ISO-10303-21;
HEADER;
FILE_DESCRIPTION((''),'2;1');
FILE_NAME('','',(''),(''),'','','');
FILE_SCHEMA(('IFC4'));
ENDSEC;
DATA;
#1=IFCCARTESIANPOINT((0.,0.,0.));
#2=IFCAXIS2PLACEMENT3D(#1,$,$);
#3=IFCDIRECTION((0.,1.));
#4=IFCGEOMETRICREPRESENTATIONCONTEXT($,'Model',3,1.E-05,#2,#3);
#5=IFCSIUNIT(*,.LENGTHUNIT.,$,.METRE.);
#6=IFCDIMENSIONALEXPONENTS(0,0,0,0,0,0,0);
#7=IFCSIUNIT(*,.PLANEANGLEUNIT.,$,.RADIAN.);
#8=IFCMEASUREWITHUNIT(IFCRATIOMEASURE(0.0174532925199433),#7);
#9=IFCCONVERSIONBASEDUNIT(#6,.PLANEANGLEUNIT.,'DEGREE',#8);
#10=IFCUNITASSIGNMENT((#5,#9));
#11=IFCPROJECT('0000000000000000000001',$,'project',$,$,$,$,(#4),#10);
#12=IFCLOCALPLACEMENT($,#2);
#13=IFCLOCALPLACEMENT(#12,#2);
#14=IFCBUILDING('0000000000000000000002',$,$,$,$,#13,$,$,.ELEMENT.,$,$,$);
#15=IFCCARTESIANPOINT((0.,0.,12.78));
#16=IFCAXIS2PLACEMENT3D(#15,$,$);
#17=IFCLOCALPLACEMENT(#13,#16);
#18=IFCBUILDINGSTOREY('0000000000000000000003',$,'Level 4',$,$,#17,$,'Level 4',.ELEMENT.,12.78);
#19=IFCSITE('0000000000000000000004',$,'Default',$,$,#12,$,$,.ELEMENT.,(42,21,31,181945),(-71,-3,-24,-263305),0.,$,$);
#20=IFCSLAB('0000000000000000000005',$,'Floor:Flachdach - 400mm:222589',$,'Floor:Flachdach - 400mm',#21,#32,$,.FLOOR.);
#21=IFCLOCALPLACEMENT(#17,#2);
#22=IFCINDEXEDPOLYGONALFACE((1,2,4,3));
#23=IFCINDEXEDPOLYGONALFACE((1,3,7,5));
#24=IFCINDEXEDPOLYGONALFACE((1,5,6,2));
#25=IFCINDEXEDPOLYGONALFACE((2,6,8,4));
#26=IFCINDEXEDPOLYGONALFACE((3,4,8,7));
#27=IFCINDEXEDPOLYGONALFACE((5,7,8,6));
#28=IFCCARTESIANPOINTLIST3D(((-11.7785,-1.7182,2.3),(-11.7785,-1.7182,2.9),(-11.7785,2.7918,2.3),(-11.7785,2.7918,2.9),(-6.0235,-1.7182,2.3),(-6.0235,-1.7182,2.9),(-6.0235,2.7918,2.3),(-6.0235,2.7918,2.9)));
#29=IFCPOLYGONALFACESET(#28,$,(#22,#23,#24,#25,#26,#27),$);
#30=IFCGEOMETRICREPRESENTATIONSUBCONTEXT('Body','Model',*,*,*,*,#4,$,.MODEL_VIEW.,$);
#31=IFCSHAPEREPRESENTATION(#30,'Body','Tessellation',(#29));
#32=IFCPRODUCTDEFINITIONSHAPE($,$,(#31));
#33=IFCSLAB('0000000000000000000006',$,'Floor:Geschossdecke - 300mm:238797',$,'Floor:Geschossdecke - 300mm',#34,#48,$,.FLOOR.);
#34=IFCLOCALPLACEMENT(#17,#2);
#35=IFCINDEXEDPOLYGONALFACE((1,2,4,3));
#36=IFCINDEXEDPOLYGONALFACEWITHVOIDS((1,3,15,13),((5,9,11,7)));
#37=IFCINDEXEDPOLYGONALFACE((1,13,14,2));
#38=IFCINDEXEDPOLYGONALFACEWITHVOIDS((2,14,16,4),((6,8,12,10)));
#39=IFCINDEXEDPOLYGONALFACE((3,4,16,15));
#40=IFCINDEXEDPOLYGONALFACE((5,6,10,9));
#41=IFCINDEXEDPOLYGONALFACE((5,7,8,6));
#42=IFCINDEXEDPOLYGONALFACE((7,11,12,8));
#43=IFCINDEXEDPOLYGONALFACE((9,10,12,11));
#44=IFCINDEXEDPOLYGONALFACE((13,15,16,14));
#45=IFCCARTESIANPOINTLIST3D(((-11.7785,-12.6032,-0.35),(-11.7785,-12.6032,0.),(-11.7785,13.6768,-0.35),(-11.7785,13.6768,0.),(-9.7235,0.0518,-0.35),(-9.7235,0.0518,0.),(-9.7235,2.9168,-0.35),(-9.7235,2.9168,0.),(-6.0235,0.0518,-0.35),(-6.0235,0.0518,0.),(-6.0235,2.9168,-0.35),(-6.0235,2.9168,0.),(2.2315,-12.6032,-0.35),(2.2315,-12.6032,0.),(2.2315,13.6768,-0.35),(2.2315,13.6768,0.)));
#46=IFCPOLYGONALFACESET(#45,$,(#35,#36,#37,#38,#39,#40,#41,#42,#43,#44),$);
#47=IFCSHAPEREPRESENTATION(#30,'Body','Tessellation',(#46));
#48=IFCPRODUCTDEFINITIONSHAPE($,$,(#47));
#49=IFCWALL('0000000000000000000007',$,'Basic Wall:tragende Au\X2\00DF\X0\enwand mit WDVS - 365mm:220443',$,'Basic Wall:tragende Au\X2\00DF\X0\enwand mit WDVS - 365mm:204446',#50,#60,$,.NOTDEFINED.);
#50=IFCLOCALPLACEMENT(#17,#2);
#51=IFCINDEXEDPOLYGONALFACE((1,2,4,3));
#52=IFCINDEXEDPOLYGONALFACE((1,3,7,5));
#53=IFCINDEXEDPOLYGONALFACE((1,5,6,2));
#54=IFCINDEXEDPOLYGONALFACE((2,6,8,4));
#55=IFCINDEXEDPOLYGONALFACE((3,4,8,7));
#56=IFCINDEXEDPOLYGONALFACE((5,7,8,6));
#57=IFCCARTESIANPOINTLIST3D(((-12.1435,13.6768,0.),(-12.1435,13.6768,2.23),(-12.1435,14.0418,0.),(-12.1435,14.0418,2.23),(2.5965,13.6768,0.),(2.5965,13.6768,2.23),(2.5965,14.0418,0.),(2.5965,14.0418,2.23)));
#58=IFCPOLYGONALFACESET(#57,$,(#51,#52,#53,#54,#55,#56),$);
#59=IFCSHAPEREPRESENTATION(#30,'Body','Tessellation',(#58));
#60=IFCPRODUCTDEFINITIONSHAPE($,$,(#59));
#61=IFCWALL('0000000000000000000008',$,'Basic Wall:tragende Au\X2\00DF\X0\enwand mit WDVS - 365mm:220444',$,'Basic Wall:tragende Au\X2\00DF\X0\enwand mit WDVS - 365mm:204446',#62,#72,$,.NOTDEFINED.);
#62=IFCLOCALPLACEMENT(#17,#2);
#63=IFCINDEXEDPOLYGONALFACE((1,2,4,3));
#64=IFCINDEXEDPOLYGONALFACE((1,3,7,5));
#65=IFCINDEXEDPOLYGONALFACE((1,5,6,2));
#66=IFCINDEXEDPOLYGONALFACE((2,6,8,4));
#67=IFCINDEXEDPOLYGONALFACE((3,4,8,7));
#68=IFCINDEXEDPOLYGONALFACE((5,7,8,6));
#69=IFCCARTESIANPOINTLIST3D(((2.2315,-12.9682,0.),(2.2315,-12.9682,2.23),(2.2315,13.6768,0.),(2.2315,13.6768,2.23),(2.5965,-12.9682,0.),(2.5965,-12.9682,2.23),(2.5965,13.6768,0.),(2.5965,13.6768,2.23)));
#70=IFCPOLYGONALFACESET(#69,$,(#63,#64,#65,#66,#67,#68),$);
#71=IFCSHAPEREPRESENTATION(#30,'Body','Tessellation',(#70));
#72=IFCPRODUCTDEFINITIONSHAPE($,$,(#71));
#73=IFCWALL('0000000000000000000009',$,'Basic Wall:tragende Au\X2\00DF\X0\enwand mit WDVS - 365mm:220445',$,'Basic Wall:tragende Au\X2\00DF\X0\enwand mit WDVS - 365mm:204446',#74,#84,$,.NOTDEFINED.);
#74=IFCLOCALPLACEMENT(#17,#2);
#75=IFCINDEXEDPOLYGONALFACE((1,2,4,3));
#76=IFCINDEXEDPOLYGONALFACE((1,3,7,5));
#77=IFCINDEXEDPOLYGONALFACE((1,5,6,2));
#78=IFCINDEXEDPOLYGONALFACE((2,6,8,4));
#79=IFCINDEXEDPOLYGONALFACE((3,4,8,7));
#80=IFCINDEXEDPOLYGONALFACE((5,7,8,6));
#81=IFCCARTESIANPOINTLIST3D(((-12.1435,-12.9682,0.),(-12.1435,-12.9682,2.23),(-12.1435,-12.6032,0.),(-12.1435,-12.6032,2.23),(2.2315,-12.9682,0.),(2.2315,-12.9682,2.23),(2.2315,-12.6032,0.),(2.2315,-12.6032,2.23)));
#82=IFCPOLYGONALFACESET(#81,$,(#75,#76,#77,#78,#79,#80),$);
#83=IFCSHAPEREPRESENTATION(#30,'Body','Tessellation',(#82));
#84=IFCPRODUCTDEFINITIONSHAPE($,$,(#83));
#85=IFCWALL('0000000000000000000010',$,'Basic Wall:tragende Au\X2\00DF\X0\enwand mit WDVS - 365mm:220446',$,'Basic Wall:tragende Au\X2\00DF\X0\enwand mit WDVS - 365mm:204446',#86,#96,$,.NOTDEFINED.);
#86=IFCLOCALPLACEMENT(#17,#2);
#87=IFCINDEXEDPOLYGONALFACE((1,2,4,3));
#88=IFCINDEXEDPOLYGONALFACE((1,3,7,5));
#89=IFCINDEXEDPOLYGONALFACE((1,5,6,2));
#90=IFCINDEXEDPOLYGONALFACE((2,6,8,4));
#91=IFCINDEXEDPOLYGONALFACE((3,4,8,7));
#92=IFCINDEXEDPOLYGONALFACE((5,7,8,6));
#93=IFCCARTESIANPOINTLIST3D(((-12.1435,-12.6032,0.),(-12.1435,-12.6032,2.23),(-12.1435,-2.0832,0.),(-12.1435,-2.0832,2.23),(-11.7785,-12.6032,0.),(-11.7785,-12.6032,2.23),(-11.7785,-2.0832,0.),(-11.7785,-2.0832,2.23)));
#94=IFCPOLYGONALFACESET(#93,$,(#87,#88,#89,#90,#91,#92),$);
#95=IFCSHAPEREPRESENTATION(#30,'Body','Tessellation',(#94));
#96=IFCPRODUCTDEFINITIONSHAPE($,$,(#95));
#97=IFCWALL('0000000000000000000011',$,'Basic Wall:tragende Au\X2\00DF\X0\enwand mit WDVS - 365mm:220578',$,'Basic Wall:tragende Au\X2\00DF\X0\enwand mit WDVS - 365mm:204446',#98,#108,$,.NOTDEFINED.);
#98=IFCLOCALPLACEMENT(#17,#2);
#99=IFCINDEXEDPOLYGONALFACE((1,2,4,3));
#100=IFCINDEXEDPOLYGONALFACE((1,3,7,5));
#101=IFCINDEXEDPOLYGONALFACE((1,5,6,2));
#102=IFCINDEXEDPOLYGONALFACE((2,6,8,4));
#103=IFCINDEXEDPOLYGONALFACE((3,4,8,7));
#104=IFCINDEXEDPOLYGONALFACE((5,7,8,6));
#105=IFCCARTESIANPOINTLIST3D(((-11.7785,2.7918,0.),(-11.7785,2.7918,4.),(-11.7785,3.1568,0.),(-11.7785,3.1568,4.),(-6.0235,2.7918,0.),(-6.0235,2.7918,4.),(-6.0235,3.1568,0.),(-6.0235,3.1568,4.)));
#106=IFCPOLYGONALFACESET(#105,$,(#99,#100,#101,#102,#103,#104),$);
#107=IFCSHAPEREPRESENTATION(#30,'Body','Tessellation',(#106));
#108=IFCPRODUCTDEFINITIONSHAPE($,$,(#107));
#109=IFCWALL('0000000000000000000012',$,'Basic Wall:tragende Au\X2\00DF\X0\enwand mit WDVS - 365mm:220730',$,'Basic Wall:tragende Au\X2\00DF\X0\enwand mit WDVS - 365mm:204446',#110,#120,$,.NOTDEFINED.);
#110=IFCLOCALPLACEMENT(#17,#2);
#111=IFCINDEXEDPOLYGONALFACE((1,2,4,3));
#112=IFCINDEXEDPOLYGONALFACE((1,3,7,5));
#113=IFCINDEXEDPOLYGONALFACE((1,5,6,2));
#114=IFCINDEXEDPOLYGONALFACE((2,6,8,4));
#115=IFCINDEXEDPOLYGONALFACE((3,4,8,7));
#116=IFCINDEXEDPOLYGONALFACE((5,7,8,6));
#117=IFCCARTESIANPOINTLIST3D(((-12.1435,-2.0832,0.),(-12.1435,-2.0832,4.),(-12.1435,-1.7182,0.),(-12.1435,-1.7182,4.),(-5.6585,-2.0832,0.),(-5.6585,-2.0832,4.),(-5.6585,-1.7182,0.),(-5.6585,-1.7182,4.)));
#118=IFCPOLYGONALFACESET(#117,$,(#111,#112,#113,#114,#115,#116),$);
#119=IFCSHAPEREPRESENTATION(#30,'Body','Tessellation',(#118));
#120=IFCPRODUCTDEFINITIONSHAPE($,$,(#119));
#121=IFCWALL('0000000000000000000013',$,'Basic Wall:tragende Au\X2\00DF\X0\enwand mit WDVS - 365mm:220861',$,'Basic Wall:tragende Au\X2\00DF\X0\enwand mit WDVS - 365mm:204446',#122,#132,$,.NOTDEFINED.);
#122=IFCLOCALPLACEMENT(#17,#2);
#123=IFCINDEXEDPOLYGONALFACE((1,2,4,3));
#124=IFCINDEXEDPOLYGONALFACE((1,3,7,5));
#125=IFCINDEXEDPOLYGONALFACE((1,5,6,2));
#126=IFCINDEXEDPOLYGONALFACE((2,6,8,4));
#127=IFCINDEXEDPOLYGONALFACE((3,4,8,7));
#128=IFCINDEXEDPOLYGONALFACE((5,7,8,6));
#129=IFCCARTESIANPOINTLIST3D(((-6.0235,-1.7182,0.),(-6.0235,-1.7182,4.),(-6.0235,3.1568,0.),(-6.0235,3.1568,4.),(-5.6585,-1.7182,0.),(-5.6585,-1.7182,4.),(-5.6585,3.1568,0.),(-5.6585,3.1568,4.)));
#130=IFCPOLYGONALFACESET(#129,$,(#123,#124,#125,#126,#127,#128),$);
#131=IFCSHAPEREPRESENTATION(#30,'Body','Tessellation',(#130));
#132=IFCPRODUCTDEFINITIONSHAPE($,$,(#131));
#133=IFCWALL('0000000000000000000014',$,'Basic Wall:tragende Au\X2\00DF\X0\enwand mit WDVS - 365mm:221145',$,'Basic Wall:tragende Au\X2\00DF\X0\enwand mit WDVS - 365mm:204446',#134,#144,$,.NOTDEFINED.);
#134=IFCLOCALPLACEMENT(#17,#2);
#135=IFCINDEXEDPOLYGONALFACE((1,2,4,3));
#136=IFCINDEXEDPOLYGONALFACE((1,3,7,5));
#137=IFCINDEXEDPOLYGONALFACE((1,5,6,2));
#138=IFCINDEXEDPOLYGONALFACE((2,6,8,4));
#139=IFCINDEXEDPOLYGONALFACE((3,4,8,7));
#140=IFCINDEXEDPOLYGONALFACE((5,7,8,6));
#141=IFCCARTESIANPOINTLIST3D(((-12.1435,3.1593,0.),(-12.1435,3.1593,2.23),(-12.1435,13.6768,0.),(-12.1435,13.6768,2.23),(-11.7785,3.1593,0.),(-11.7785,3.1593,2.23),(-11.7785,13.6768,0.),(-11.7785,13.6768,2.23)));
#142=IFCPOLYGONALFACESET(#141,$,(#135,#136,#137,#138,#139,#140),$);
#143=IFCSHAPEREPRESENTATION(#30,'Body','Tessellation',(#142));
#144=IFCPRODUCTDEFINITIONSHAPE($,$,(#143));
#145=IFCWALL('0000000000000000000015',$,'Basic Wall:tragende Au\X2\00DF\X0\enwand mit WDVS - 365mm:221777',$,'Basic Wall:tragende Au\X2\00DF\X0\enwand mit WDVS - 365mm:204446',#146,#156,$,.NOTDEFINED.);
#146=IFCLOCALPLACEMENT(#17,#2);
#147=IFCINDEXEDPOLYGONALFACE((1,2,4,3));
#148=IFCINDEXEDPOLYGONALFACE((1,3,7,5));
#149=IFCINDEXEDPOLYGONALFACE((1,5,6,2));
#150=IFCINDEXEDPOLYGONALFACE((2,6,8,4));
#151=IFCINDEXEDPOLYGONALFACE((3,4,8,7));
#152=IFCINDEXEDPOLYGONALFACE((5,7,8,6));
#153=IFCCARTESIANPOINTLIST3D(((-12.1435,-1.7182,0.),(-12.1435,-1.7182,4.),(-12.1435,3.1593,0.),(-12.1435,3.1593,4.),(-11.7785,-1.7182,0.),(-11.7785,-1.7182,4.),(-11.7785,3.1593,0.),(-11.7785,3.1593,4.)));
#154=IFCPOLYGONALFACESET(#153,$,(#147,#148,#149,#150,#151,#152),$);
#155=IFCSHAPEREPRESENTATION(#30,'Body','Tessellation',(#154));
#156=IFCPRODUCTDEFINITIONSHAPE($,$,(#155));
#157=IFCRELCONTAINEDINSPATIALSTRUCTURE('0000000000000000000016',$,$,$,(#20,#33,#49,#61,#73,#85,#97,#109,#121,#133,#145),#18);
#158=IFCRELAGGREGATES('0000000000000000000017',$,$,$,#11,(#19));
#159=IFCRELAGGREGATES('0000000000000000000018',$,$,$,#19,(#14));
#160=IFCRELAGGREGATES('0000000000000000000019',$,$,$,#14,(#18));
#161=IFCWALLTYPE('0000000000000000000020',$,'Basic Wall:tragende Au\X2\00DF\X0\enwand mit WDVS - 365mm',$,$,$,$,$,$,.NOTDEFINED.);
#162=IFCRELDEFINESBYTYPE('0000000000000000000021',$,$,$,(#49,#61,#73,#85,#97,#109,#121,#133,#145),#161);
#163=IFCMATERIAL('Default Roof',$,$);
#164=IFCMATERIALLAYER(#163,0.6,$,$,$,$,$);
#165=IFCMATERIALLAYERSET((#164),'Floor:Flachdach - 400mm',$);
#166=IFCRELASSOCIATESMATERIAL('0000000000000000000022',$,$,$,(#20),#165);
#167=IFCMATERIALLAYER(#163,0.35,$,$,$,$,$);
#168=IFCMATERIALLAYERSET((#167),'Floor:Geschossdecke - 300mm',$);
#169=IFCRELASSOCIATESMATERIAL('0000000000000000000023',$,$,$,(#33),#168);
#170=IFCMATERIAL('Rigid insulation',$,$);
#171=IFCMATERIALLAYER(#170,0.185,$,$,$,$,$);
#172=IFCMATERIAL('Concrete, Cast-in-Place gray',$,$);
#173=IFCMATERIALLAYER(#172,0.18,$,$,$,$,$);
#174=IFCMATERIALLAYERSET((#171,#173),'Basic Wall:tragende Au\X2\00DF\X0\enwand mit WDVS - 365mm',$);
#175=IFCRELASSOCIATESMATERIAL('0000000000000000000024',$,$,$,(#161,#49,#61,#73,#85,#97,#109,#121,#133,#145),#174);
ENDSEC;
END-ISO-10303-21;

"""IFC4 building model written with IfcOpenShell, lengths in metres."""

from ifc_helpers import new_model, entity, si_unit, converted_unit, direction, frame, frame_2d, origin, origin_2d_with_axis, place, context, subcontext, project, spatial, rectangle, extrude, material, layer, layer_set, layer_usage, type_object, element, save


model = new_model("IFC4")

# Units and contexts
model_context = context("Model", 3, precision=1e-05, world=origin(), true_north=direction((0.0, 1.0)))
body_context = subcontext(model_context, "Body", "Model", "MODEL_VIEW")
ifc_project = project(units=[si_unit("LENGTHUNIT", "METRE"), converted_unit("PLANEANGLEUNIT", "DEGREE", entity("IfcRatioMeasure", 0.0174532925199433), si_unit("PLANEANGLEUNIT", "RADIAN"), dimensions=[0, 0, 0, 0, 0, 0, 0])], contexts=[model_context])

# Site, building, storey
site_placement = place(None, origin())
site = spatial("IfcSite", under=ifc_project, at=site_placement, Name="Default", CompositionType="ELEMENT", RefLatitude=(42, 21, 31, 181945), RefLongitude=(-71, -3, -24, -263305), RefElevation=0.0)
building_placement = place(site_placement, origin())
building = spatial("IfcBuilding", under=site, at=building_placement, CompositionType="ELEMENT")
storey_placement = place(building_placement, frame((0.0, 0.0, 12.78)))
storey = spatial("IfcBuildingStorey", under=building, at=storey_placement, Name="Level 4", LongName="Level 4", CompositionType="ELEMENT", Elevation=12.78)

# Slab
ifc_material_1 = material(Name="Default Roof")
ifc_layer_1 = layer(ifc_material_1, 0.6)
ifc_layer_set_1 = layer_set([ifc_layer_1], Name="Floor:Flachdach - 400mm")
ifc_layer_usage_1 = layer_usage(ifc_layer_set_1, "AXIS3", "POSITIVE", 0.0)
slab_1_placement = place(storey_placement, origin())
element("IfcSlab", 1, at=slab_1_placement, inside=storey, material=ifc_layer_usage_1, Name="Floor:Flachdach - 400mm:222589", ObjectType="Floor:Flachdach - 400mm", PredefinedType="FLOOR", context=body_context, shape_type="SweptSolid", body=[
    extrude(rectangle(XDim=4.51, YDim=5.755, at=frame_2d((0.0, 0.0), x_axis=(1.0, 0.0))), frame((-8.901, 0.5368, 2.9), z_axis=(0.0, 0.0, -1.0), x_axis=(0.0, 1.0, 0.0)), (0.0, 0.0, 1.0), 0.6),
])

# Slab, opening
ifc_layer_2 = layer(ifc_material_1, 0.35)
ifc_layer_set_2 = layer_set([ifc_layer_2], Name="Floor:Geschossdecke - 300mm")
ifc_layer_usage_2 = layer_usage(ifc_layer_set_2, "AXIS3", "POSITIVE", 0.0)
slab_2_placement = place(storey_placement, frame((-11.7785, -12.6032, -0.35)))
slab_2 = element("IfcSlab", 2, at=slab_2_placement, inside=storey, material=ifc_layer_usage_2, Name="Floor:Geschossdecke - 300mm:238797", ObjectType="Floor:Geschossdecke - 300mm", PredefinedType="FLOOR", context=body_context, shape_type="SweptSolid", body=[
    extrude(rectangle(XDim=26.28, YDim=14.01, at=frame_2d((0.0, 0.0), x_axis=(0.0, -1.0))), frame((7.005, 13.14, 0.35), z_axis=(0.0, 0.0, -1.0), x_axis=(-1.0, 0.0, 0.0)), (0.0, 0.0, 1.0), 0.35),
])
opening_placement = place(slab_2_placement, frame((3.905, 14.0875, 0.35)))
element("IfcOpeningElement", 3, at=opening_placement, cuts=slab_2, ObjectType="Opening", context=body_context, shape_type="SweptSolid", body=[
    extrude(rectangle(XDim=3.7, YDim=2.865, at=origin_2d_with_axis()), frame((0.0, 0.0, 0.0), z_axis=(0.0, 0.0, -1.0), x_axis=(1.0, 0.0, 0.0)), (0.0, 0.0, 1.0), 0.35),
])

# Walls
ifc_material_2 = material(Name="Rigid insulation")
ifc_layer_3 = layer(ifc_material_2, 0.185)
ifc_material_3 = material(Name="Concrete, Cast-in-Place gray")
ifc_layer_4 = layer(ifc_material_3, 0.18)
ifc_layer_set_3 = layer_set([ifc_layer_3, ifc_layer_4], Name="Basic Wall:tragende Außenwand mit WDVS - 365mm")
ifc_layer_usage_3 = layer_usage(ifc_layer_set_3, "AXIS2", "NEGATIVE", 0.1825)
wall_type = type_object("IfcWallType", Name="Basic Wall:tragende Außenwand mit WDVS - 365mm", PredefinedType="NOTDEFINED", material=ifc_layer_set_3)
wall_1_placement = place(storey_placement, frame((-12.1435, 13.8593, 0.0)))
element("IfcWall", 4, at=wall_1_placement, inside=storey, type_object=wall_type, material=ifc_layer_usage_3, Name="Basic Wall:tragende Außenwand mit WDVS - 365mm:220443", ObjectType="Basic Wall:tragende Außenwand mit WDVS - 365mm:204446", PredefinedType="NOTDEFINED", context=body_context, shape_type="SweptSolid", body=[
    extrude(rectangle(XDim=14.74, YDim=0.365, at=frame_2d((7.37, 0.0), x_axis=(-1.0, 0.0))), origin(), (0.0, 0.0, 1.0), 2.23),
])
ifc_layer_usage_4 = layer_usage(ifc_layer_set_3, "AXIS2", "NEGATIVE", 0.1825)
wall_2_placement = place(storey_placement, frame((2.414, 13.6768, 0.0), z_axis=(0.0, 0.0, 1.0), x_axis=(0.0, -1.0, 0.0)))
element("IfcWall", 5, at=wall_2_placement, inside=storey, type_object=wall_type, material=ifc_layer_usage_4, Name="Basic Wall:tragende Außenwand mit WDVS - 365mm:220444", ObjectType="Basic Wall:tragende Außenwand mit WDVS - 365mm:204446", PredefinedType="NOTDEFINED", context=body_context, shape_type="SweptSolid", body=[
    extrude(rectangle(XDim=26.645, YDim=0.365, at=frame_2d((13.3225, 0.0), x_axis=(-1.0, 0.0))), origin(), (0.0, 0.0, 1.0), 2.23),
])
ifc_layer_usage_5 = layer_usage(ifc_layer_set_3, "AXIS2", "NEGATIVE", 0.1825)
wall_3_placement = place(storey_placement, frame((2.2315, -12.7857, 0.0), z_axis=(0.0, 0.0, 1.0), x_axis=(-1.0, 0.0, 0.0)))
element("IfcWall", 6, at=wall_3_placement, inside=storey, type_object=wall_type, material=ifc_layer_usage_5, Name="Basic Wall:tragende Außenwand mit WDVS - 365mm:220445", ObjectType="Basic Wall:tragende Außenwand mit WDVS - 365mm:204446", PredefinedType="NOTDEFINED", context=body_context, shape_type="SweptSolid", body=[
    extrude(rectangle(XDim=14.375, YDim=0.365, at=frame_2d((7.1875, 0.0), x_axis=(-1.0, 0.0))), origin(), (0.0, 0.0, 1.0), 2.23),
])
ifc_layer_usage_6 = layer_usage(ifc_layer_set_3, "AXIS2", "NEGATIVE", 0.1825)
wall_4_placement = place(storey_placement, frame((-11.961, -12.6032, 0.0), z_axis=(0.0, 0.0, 1.0), x_axis=(0.0, 1.0, 0.0)))
element("IfcWall", 7, at=wall_4_placement, inside=storey, type_object=wall_type, material=ifc_layer_usage_6, Name="Basic Wall:tragende Außenwand mit WDVS - 365mm:220446", ObjectType="Basic Wall:tragende Außenwand mit WDVS - 365mm:204446", PredefinedType="NOTDEFINED", context=body_context, shape_type="SweptSolid", body=[
    extrude(rectangle(XDim=10.52, YDim=0.365, at=frame_2d((5.26, 0.0), x_axis=(-1.0, 0.0))), origin(), (0.0, 0.0, 1.0), 2.23),
])
ifc_layer_usage_7 = layer_usage(ifc_layer_set_3, "AXIS2", "NEGATIVE", 0.1825)
wall_5_placement = place(storey_placement, frame((-11.7785, 2.9743, 0.0)))
element("IfcWall", 8, at=wall_5_placement, inside=storey, type_object=wall_type, material=ifc_layer_usage_7, Name="Basic Wall:tragende Außenwand mit WDVS - 365mm:220578", ObjectType="Basic Wall:tragende Außenwand mit WDVS - 365mm:204446", PredefinedType="NOTDEFINED", context=body_context, shape_type="SweptSolid", body=[
    extrude(rectangle(XDim=5.755, YDim=0.365, at=frame_2d((2.8775, 0.0), x_axis=(-1.0, 0.0))), origin(), (0.0, 0.0, 1.0), 4.0),
])
ifc_layer_usage_8 = layer_usage(ifc_layer_set_3, "AXIS2", "NEGATIVE", 0.1825)
wall_6_placement = place(storey_placement, frame((-12.1435, -1.9007, 0.0)))
element("IfcWall", 9, at=wall_6_placement, inside=storey, type_object=wall_type, material=ifc_layer_usage_8, Name="Basic Wall:tragende Außenwand mit WDVS - 365mm:220730", ObjectType="Basic Wall:tragende Außenwand mit WDVS - 365mm:204446", PredefinedType="NOTDEFINED", context=body_context, shape_type="SweptSolid", body=[
    extrude(rectangle(XDim=6.485, YDim=0.365, at=frame_2d((3.2425, 0.0), x_axis=(-1.0, 0.0))), origin(), (0.0, 0.0, 1.0), 4.0),
])
ifc_layer_usage_9 = layer_usage(ifc_layer_set_3, "AXIS2", "NEGATIVE", 0.1825)
wall_7_placement = place(storey_placement, frame((-5.841, -1.7182, 0.0), z_axis=(0.0, 0.0, 1.0), x_axis=(0.0, 1.0, 0.0)))
element("IfcWall", 10, at=wall_7_placement, inside=storey, type_object=wall_type, material=ifc_layer_usage_9, Name="Basic Wall:tragende Außenwand mit WDVS - 365mm:220861", ObjectType="Basic Wall:tragende Außenwand mit WDVS - 365mm:204446", PredefinedType="NOTDEFINED", context=body_context, shape_type="SweptSolid", body=[
    extrude(rectangle(XDim=4.875, YDim=0.365, at=frame_2d((2.4375, 0.0), x_axis=(-1.0, 0.0))), origin(), (0.0, 0.0, 1.0), 4.0),
])
ifc_layer_usage_10 = layer_usage(ifc_layer_set_3, "AXIS2", "NEGATIVE", 0.1825)
wall_8_placement = place(storey_placement, frame((-11.961, 3.1593, 0.0), z_axis=(0.0, 0.0, 1.0), x_axis=(0.0, 1.0, 0.0)))
element("IfcWall", 11, at=wall_8_placement, inside=storey, type_object=wall_type, material=ifc_layer_usage_10, Name="Basic Wall:tragende Außenwand mit WDVS - 365mm:221145", ObjectType="Basic Wall:tragende Außenwand mit WDVS - 365mm:204446", PredefinedType="NOTDEFINED", context=body_context, shape_type="SweptSolid", body=[
    extrude(rectangle(XDim=10.5175, YDim=0.365, at=frame_2d((5.2588, 0.0), x_axis=(-1.0, 0.0))), origin(), (0.0, 0.0, 1.0), 2.23),
])
ifc_layer_usage_11 = layer_usage(ifc_layer_set_3, "AXIS2", "NEGATIVE", 0.1825)
wall_9_placement = place(storey_placement, frame((-11.961, -1.7182, 0.0), z_axis=(0.0, 0.0, 1.0), x_axis=(0.0, 1.0, 0.0)))
element("IfcWall", 12, at=wall_9_placement, inside=storey, type_object=wall_type, material=ifc_layer_usage_11, Name="Basic Wall:tragende Außenwand mit WDVS - 365mm:221777", ObjectType="Basic Wall:tragende Außenwand mit WDVS - 365mm:204446", PredefinedType="NOTDEFINED", context=body_context, shape_type="SweptSolid", body=[
    extrude(rectangle(XDim=4.8775, YDim=0.365, at=frame_2d((2.4387, 0.0), x_axis=(-1.0, 0.0))), origin(), (0.0, 0.0, 1.0), 4.0),
])

save(model, "model.ifc")
